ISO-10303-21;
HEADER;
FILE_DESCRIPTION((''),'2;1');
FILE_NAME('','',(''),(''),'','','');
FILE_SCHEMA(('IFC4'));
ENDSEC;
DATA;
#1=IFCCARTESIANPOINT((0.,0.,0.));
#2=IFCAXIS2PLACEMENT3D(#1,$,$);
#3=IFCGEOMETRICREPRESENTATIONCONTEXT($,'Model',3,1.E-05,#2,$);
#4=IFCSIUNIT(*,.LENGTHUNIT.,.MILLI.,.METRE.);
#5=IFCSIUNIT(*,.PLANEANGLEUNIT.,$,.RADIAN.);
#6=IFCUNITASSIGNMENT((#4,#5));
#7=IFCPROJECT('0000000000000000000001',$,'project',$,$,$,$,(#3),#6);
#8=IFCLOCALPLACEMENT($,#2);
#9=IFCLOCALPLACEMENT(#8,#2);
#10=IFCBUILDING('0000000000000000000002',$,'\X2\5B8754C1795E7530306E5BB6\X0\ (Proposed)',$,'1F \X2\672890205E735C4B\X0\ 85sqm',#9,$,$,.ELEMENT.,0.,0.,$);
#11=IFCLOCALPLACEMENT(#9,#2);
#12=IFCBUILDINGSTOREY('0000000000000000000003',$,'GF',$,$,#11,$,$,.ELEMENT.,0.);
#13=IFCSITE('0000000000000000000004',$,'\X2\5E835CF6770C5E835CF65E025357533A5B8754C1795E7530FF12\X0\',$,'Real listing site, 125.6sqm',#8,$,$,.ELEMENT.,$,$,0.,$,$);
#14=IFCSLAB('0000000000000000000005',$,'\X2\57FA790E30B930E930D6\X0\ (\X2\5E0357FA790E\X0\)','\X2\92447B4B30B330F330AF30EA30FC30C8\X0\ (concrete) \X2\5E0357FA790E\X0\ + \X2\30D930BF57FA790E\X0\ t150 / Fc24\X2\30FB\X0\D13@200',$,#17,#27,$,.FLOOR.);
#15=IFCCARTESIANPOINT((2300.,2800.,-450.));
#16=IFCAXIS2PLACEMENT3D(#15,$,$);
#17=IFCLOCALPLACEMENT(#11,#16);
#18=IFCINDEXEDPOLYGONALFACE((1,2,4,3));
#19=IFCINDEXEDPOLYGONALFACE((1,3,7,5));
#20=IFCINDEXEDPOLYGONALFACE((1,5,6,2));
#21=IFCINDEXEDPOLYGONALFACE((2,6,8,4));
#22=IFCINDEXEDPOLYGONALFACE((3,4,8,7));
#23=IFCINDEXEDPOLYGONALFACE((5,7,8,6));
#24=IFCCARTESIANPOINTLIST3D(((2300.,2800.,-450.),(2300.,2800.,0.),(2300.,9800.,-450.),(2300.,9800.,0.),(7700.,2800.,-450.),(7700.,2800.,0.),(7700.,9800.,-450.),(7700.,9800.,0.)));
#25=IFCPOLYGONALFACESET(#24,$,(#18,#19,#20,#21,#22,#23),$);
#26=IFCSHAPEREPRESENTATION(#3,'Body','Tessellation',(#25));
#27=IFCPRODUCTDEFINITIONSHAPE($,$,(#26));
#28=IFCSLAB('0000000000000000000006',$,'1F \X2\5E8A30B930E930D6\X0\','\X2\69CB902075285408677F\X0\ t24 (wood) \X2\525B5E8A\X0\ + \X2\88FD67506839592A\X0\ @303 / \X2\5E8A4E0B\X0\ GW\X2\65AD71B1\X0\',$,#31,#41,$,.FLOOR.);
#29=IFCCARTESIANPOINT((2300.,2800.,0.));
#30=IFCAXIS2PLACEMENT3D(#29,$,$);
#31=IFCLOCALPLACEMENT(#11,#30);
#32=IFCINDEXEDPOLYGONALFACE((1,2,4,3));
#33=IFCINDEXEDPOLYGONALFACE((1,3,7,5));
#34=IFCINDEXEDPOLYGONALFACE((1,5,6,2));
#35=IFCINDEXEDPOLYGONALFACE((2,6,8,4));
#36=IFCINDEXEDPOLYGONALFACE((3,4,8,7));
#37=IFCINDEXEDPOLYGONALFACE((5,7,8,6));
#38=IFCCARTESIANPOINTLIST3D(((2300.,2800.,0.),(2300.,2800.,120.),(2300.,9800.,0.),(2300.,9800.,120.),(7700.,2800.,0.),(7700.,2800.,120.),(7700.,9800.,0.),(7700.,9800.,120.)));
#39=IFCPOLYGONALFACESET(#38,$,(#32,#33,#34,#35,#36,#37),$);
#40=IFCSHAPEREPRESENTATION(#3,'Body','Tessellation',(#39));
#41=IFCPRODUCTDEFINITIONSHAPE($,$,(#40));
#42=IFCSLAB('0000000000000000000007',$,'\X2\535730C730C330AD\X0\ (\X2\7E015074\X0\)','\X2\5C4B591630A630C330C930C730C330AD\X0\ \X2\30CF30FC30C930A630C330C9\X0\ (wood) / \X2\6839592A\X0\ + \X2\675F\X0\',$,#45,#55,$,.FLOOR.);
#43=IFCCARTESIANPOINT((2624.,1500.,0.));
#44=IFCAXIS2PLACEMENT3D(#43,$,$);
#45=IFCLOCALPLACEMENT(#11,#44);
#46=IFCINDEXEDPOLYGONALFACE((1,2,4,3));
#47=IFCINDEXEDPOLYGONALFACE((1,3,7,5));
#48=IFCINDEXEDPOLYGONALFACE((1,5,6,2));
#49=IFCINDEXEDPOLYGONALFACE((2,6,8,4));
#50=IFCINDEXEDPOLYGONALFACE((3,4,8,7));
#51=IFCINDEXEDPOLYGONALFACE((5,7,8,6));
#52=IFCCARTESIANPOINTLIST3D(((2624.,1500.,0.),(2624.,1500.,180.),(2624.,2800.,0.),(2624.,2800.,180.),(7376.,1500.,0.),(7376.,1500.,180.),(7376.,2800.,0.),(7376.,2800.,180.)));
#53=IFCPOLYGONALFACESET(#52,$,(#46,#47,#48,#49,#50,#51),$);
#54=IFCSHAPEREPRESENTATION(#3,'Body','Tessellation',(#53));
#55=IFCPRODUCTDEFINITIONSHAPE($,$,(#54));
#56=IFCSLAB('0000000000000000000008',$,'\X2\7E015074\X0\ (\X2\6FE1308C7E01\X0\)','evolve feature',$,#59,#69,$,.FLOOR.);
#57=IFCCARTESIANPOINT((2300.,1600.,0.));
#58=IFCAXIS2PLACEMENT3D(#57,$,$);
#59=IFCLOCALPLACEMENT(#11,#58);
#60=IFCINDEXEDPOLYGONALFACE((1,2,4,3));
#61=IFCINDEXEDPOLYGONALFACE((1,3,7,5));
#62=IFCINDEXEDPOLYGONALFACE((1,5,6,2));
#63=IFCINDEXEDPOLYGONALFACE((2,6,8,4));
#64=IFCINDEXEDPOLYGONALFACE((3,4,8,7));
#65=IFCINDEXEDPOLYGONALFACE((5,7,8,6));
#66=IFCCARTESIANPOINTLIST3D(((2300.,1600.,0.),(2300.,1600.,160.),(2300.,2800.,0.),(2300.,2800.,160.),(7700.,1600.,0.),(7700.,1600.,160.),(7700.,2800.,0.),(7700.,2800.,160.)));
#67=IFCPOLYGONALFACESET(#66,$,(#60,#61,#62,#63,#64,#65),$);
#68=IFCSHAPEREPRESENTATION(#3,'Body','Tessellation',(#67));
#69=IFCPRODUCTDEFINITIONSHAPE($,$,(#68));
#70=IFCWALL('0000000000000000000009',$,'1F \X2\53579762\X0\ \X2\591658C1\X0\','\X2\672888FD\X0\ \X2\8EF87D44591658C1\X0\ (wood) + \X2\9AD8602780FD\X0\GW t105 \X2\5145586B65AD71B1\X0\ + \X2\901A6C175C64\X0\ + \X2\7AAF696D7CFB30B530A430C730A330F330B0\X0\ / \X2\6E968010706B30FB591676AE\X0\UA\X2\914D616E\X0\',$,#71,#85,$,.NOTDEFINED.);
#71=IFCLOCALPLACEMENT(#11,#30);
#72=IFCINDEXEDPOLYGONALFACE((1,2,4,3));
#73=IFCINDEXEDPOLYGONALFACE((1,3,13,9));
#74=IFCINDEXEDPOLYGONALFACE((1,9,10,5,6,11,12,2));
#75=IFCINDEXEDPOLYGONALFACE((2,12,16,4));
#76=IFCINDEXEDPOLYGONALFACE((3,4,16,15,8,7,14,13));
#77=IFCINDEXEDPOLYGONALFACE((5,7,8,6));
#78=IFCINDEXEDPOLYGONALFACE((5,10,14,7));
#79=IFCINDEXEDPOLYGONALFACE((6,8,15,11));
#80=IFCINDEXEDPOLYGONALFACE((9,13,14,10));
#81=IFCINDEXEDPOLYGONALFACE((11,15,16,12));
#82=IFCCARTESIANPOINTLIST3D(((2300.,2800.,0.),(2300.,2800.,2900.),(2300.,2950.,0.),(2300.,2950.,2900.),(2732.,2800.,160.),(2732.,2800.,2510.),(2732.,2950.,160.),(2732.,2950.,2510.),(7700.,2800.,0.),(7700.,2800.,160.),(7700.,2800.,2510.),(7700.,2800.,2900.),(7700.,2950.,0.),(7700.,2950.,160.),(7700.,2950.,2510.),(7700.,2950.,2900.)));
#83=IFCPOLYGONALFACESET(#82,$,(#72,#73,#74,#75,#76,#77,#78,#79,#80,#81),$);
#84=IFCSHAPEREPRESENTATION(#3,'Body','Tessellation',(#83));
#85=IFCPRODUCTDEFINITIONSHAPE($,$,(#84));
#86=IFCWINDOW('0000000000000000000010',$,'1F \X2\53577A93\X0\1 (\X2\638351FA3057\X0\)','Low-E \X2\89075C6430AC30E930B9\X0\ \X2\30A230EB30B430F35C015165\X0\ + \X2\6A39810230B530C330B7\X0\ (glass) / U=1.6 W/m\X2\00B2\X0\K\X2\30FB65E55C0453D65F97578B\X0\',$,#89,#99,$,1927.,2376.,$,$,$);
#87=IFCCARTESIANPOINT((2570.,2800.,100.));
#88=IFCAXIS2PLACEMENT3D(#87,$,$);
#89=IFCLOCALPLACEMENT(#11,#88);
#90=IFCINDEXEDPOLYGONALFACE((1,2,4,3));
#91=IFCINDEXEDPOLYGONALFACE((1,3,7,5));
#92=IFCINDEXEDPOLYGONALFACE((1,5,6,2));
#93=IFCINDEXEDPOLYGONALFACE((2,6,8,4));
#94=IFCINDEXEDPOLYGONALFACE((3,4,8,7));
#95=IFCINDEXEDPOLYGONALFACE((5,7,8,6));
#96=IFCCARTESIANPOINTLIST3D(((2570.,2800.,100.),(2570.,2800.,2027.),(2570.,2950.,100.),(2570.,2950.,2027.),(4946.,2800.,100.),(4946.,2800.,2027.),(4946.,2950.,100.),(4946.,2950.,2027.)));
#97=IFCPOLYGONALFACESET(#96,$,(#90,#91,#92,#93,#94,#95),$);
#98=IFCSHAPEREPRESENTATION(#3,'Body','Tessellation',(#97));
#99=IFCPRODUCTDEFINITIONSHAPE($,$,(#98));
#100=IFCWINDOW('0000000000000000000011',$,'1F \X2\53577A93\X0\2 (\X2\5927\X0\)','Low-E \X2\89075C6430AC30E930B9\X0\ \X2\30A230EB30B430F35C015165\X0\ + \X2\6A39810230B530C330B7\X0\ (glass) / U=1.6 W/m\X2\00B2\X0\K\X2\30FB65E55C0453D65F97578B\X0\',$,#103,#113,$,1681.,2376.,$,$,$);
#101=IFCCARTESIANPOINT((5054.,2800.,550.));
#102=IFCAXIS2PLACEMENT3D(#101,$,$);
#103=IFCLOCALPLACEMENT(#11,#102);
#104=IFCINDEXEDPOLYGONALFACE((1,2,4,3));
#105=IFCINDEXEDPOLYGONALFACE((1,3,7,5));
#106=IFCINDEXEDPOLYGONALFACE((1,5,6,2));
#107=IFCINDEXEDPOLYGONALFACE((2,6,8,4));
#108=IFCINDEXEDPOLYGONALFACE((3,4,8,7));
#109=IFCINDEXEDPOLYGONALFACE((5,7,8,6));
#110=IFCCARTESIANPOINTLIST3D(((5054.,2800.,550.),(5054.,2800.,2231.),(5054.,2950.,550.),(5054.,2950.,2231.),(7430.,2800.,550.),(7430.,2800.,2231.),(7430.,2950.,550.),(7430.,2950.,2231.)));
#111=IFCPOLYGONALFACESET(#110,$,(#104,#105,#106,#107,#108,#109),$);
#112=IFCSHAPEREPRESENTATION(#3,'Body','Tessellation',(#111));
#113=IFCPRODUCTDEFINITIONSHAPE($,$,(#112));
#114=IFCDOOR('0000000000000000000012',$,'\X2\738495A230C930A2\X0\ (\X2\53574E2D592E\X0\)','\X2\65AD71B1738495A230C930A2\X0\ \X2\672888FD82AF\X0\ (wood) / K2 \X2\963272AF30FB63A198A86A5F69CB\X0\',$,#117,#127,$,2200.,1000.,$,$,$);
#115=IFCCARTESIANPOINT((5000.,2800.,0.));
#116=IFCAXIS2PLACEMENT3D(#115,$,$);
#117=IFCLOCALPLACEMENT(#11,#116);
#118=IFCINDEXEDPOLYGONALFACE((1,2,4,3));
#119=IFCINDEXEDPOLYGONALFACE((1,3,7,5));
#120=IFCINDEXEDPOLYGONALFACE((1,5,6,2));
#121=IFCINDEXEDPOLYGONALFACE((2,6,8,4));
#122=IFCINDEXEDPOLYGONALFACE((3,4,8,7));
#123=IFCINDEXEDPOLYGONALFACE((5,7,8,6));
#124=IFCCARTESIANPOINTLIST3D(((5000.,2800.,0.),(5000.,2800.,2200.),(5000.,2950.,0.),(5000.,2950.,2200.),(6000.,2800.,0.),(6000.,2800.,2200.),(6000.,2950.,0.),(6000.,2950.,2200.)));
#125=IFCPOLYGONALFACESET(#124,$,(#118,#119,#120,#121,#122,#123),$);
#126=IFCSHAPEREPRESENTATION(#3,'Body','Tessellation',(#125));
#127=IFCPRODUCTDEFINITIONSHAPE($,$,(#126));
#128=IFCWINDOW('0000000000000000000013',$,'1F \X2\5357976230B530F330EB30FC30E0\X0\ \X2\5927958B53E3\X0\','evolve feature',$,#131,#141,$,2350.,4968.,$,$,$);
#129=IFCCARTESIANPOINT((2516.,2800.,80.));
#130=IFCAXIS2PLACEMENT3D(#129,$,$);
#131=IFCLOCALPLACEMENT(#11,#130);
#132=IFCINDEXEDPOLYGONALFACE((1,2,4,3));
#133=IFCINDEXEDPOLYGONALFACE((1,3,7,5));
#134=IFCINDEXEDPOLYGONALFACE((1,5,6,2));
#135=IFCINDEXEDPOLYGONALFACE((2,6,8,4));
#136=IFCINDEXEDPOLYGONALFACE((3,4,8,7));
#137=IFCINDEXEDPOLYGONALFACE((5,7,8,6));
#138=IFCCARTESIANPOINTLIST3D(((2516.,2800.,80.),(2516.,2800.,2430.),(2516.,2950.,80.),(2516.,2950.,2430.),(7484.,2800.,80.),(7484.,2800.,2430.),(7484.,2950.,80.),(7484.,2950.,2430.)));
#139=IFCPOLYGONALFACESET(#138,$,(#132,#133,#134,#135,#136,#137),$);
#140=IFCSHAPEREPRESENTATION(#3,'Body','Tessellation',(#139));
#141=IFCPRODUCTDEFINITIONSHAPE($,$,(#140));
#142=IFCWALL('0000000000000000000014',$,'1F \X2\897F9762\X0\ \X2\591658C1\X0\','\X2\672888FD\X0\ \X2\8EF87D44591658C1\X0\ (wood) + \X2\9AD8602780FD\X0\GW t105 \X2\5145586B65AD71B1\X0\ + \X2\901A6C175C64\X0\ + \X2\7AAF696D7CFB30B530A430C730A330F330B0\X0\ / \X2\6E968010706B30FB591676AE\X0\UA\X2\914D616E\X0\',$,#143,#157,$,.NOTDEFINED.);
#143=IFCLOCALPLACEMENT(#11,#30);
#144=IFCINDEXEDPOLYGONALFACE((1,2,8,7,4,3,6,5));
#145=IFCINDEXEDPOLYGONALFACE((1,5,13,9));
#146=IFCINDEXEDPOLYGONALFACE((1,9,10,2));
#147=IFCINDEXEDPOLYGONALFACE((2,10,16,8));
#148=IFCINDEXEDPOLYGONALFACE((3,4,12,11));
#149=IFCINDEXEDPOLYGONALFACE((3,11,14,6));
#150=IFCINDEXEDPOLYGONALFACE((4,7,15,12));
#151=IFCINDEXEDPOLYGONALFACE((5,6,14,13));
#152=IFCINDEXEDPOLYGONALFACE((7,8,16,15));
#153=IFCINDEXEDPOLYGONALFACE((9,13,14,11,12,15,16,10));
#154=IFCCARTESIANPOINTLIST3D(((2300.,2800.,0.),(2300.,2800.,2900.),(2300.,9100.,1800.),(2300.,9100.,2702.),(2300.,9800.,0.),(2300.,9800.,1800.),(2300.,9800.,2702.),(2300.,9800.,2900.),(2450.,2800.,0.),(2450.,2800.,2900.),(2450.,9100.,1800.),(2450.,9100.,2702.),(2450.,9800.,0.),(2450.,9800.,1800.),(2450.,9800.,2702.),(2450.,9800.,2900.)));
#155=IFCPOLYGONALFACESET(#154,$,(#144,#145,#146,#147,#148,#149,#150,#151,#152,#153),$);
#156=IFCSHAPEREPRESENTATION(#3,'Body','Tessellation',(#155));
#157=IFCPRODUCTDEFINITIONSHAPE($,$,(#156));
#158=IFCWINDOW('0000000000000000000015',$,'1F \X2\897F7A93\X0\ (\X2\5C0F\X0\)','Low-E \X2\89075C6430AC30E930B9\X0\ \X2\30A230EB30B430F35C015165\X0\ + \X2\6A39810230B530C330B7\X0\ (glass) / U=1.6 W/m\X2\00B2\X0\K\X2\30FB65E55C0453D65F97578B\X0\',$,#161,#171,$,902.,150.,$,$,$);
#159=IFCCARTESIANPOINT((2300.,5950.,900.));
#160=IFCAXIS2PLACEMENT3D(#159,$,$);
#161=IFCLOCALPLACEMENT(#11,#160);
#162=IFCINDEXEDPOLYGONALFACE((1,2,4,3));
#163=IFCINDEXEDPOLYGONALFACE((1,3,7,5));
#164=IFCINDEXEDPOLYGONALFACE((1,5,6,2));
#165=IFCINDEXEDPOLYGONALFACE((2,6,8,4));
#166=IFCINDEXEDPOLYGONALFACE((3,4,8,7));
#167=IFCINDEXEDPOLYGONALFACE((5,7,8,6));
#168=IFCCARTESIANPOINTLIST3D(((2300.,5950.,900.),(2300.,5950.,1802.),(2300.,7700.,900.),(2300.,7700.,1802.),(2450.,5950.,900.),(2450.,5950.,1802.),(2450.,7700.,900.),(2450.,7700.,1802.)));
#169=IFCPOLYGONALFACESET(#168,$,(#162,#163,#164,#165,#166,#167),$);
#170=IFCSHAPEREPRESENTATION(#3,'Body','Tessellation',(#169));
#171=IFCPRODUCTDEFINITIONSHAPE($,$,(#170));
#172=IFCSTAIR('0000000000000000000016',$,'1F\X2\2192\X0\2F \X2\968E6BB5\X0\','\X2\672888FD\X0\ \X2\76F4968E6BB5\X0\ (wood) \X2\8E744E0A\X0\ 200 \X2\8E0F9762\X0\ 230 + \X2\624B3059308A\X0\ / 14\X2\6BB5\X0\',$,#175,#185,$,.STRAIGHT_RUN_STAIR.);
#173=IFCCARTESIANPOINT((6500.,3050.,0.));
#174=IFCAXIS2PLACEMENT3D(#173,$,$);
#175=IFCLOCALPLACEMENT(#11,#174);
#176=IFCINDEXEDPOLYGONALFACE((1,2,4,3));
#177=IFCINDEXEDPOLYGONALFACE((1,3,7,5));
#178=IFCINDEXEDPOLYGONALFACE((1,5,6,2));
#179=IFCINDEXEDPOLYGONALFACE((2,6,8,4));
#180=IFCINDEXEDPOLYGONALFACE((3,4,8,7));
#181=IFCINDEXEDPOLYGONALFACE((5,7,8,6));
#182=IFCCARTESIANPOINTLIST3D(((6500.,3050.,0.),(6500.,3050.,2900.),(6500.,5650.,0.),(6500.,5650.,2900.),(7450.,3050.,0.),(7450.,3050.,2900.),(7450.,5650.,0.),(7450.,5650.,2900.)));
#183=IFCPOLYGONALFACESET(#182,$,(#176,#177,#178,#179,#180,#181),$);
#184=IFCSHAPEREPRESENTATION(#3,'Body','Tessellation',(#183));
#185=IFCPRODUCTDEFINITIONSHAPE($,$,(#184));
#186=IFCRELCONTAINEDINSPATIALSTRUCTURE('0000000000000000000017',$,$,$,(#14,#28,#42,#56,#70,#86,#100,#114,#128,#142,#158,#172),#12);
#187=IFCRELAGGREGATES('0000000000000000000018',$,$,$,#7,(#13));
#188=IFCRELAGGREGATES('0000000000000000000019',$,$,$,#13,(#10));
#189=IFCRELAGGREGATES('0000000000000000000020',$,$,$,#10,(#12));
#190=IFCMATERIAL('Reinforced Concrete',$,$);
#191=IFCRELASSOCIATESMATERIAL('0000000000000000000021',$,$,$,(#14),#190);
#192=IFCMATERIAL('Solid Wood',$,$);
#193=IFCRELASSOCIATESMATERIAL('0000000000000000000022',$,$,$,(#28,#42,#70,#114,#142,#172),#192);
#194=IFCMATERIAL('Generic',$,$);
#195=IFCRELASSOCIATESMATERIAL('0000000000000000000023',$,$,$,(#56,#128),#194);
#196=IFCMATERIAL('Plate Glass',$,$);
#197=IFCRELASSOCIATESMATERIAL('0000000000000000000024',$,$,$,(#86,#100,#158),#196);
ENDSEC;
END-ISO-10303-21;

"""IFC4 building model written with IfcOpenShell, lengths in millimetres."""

from ifc_helpers import new_model, si_unit, frame, frame_2d, origin, place, context, project, spatial, rectangle, extrude, material, element, fill, save


model = new_model("IFC4")

# Units and contexts
model_context = context("Model", 3, precision=1e-05, world=origin())
ifc_project = project(units=[si_unit("LENGTHUNIT", "METRE", prefix="MILLI"), si_unit("PLANEANGLEUNIT", "RADIAN")], contexts=[model_context])

# Site, building, storey
site_placement = place(None, origin())
site = spatial("IfcSite", under=ifc_project, at=site_placement, Name="広島県広島市南区宇品神田２", ObjectType="Real listing site, 125.6sqm", CompositionType="ELEMENT", RefElevation=0.0)
building_placement = place(site_placement, origin())
building = spatial("IfcBuilding", under=site, at=building_placement, Name="宇品神田の家 (Proposed)", ObjectType="1F 木造平屋 85sqm", CompositionType="ELEMENT", ElevationOfRefHeight=0.0, ElevationOfTerrain=0.0)
storey_placement = place(building_placement, origin())
storey = spatial("IfcBuildingStorey", under=building, at=storey_placement, Name="GF", CompositionType="ELEMENT", Elevation=0.0)

# Slabs
ifc_material_1 = material(Name="Reinforced Concrete")
slab_1_placement = place(storey_placement, frame((2300.0, 2800.0, -450.0)))
element("IfcSlab", 1, at=slab_1_placement, inside=storey, material=ifc_material_1, Name="基礎スラブ (布基礎)", Description="鉄筋コンクリート (concrete) 布基礎 + ベタ基礎 t150 / Fc24・D13@200", PredefinedType="FLOOR", context=model_context, shape_type="SweptSolid", body=[
    extrude(rectangle(XDim=5400.0, YDim=7000.0, at=frame_2d((2700.0, 3500.0))), frame((2300.0, 2800.0, -450.0)), (0.0, 0.0, 1.0), 450.0),
])
ifc_material_2 = material(Name="Solid Wood")
slab_2_placement = place(storey_placement, frame((2300.0, 2800.0, 0.0)))
element("IfcSlab", 2, at=slab_2_placement, inside=storey, material=ifc_material_2, Name="1F 床スラブ", Description="構造用合板 t24 (wood) 剛床 + 製材根太 @303 / 床下 GW断熱", PredefinedType="FLOOR", context=model_context, shape_type="SweptSolid", body=[
    extrude(rectangle(XDim=5400.0, YDim=7000.0, at=frame_2d((2700.0, 3500.0))), frame((2300.0, 2800.0, 0.0)), (0.0, 0.0, 1.0), 120.0),
])
slab_3_placement = place(storey_placement, frame((2624.0, 1500.0, 0.0)))
element("IfcSlab", 3, at=slab_3_placement, inside=storey, material=ifc_material_2, Name="南デッキ (縁側)", Description="屋外ウッドデッキ ハードウッド (wood) / 根太 + 束", PredefinedType="FLOOR", context=model_context, shape_type="SweptSolid", body=[
    extrude(rectangle(XDim=4752.0, YDim=1300.0, at=frame_2d((2376.0, 650.0))), frame((2624.0, 1500.0, 0.0)), (0.0, 0.0, 1.0), 180.0),
])
ifc_material_3 = material(Name="Generic")
slab_4_placement = place(storey_placement, frame((2300.0, 1600.0, 0.0)))
element("IfcSlab", 4, at=slab_4_placement, inside=storey, material=ifc_material_3, Name="縁側 (濡れ縁)", Description="evolve feature", PredefinedType="FLOOR", context=model_context, shape_type="SweptSolid", body=[
    extrude(rectangle(XDim=5400.0, YDim=1200.0, at=frame_2d((2700.0, 600.0))), frame((2300.0, 1600.0, 0.0)), (0.0, 0.0, 1.0), 160.0),
])

# Wall, openings, windows, door
wall_1_placement = place(storey_placement, frame((2300.0, 2800.0, 0.0)))
wall_1 = element("IfcWall", 5, at=wall_1_placement, inside=storey, material=ifc_material_2, Name="1F 南面 外壁", Description="木製 軸組外壁 (wood) + 高性能GW t105 充填断熱 + 通気層 + 窯業系サイディング / 準耐火・外皮UA配慮", PredefinedType="NOTDEFINED", context=model_context, shape_type="SweptSolid", body=[
    extrude(rectangle(XDim=5400.0, YDim=150.0, at=frame_2d((2700.0, 75.0))), frame((2300.0, 2800.0, 0.0)), (0.0, 0.0, 1.0), 2900.0),
])
opening_1_placement = place(storey_placement, frame((2570.0, 2800.0, 100.0)))
opening_1 = element("IfcOpeningElement", 6, at=opening_1_placement, cuts=wall_1, PredefinedType="NOTDEFINED", context=model_context, shape_type="SweptSolid", body=[
    extrude(rectangle(XDim=2376.0, YDim=150.0, at=frame_2d((1188.0, 75.0))), frame((2570.0, 2800.0, 100.0)), (0.0, 0.0, 1.0), 1927.0),
])
opening_2_placement = place(storey_placement, frame((5054.0, 2800.0, 550.0)))
opening_2 = element("IfcOpeningElement", 7, at=opening_2_placement, cuts=wall_1, PredefinedType="NOTDEFINED", context=model_context, shape_type="SweptSolid", body=[
    extrude(rectangle(XDim=2376.0, YDim=150.0, at=frame_2d((1188.0, 75.0))), frame((5054.0, 2800.0, 550.0)), (0.0, 0.0, 1.0), 1681.0),
])
opening_3_placement = place(storey_placement, frame((5000.0, 2800.0, 0.0)))
opening_3 = element("IfcOpeningElement", 8, at=opening_3_placement, cuts=wall_1, PredefinedType="NOTDEFINED", context=model_context, shape_type="SweptSolid", body=[
    extrude(rectangle(XDim=1000.0, YDim=150.0, at=frame_2d((500.0, 75.0))), frame((5000.0, 2800.0, 0.0)), (0.0, 0.0, 1.0), 2200.0),
])
opening_4_placement = place(storey_placement, frame((2516.0, 2800.0, 80.0)))
opening_4 = element("IfcOpeningElement", 9, at=opening_4_placement, cuts=wall_1, PredefinedType="NOTDEFINED", context=model_context, shape_type="SweptSolid", body=[
    extrude(rectangle(XDim=4968.0, YDim=150.0, at=frame_2d((2484.0, 75.0))), frame((2516.0, 2800.0, 80.0)), (0.0, 0.0, 1.0), 2350.0),
])
ifc_material_4 = material(Name="Plate Glass")
window_1_placement = place(storey_placement, frame((2570.0, 2800.0, 100.0)))
window_1 = element("IfcWindow", 10, at=window_1_placement, inside=storey, material=ifc_material_4, Name="1F 南窓1 (掃出し)", Description="Low-E 複層ガラス アルゴン封入 + 樹脂サッシ (glass) / U=1.6 W/m²K・日射取得型", OverallHeight=1927.0, OverallWidth=2376.0, context=model_context, shape_type="SweptSolid", body=[
    extrude(rectangle(XDim=2376.0, YDim=150.0, at=frame_2d((1188.0, 75.0))), frame((2570.0, 2800.0, 100.0)), (0.0, 0.0, 1.0), 1927.0),
])
fill(opening_1, window_1)
window_2_placement = place(storey_placement, frame((5054.0, 2800.0, 550.0)))
window_2 = element("IfcWindow", 11, at=window_2_placement, inside=storey, material=ifc_material_4, Name="1F 南窓2 (大)", Description="Low-E 複層ガラス アルゴン封入 + 樹脂サッシ (glass) / U=1.6 W/m²K・日射取得型", OverallHeight=1681.0, OverallWidth=2376.0, context=model_context, shape_type="SweptSolid", body=[
    extrude(rectangle(XDim=2376.0, YDim=150.0, at=frame_2d((1188.0, 75.0))), frame((5054.0, 2800.0, 550.0)), (0.0, 0.0, 1.0), 1681.0),
])
fill(opening_2, window_2)
door_placement = place(storey_placement, frame((5000.0, 2800.0, 0.0)))
door = element("IfcDoor", 12, at=door_placement, inside=storey, material=ifc_material_2, Name="玄関ドア (南中央)", Description="断熱玄関ドア 木製芯 (wood) / K2 防犯・採風機構", OverallHeight=2200.0, OverallWidth=1000.0, context=model_context, shape_type="SweptSolid", body=[
    extrude(rectangle(XDim=1000.0, YDim=150.0, at=frame_2d((500.0, 75.0))), frame((5000.0, 2800.0, 0.0)), (0.0, 0.0, 1.0), 2200.0),
])
fill(opening_3, door)
window_3_placement = place(storey_placement, frame((2516.0, 2800.0, 80.0)))
window_3 = element("IfcWindow", 13, at=window_3_placement, inside=storey, material=ifc_material_3, Name="1F 南面サンルーム 大開口", Description="evolve feature", OverallHeight=2350.0, OverallWidth=4968.0, context=model_context, shape_type="SweptSolid", body=[
    extrude(rectangle(XDim=4968.0, YDim=150.0, at=frame_2d((2484.0, 75.0))), frame((2516.0, 2800.0, 80.0)), (0.0, 0.0, 1.0), 2350.0),
])
fill(opening_4, window_3)

# Wall, opening, window
wall_2_placement = place(storey_placement, frame((2300.0, 2800.0, 0.0)))
wall_2 = element("IfcWall", 14, at=wall_2_placement, inside=storey, material=ifc_material_2, Name="1F 西面 外壁", Description="木製 軸組外壁 (wood) + 高性能GW t105 充填断熱 + 通気層 + 窯業系サイディング / 準耐火・外皮UA配慮", PredefinedType="NOTDEFINED", context=model_context, shape_type="SweptSolid", body=[
    extrude(rectangle(XDim=150.0, YDim=7000.0, at=frame_2d((75.0, 3500.0))), frame((2300.0, 2800.0, 0.0)), (0.0, 0.0, 1.0), 2900.0),
])
opening_5_placement = place(storey_placement, frame((2300.0, 5950.0, 900.0)))
opening_5 = element("IfcOpeningElement", 15, at=opening_5_placement, cuts=wall_2, PredefinedType="NOTDEFINED", context=model_context, shape_type="SweptSolid", body=[
    extrude(rectangle(XDim=150.0, YDim=1750.0, at=frame_2d((75.0, 875.0))), frame((2300.0, 5950.0, 900.0)), (0.0, 0.0, 1.0), 902.0),
])
window_4_placement = place(storey_placement, frame((2300.0, 5950.0, 900.0)))
window_4 = element("IfcWindow", 16, at=window_4_placement, inside=storey, material=ifc_material_4, Name="1F 西窓 (小)", Description="Low-E 複層ガラス アルゴン封入 + 樹脂サッシ (glass) / U=1.6 W/m²K・日射取得型", OverallHeight=902.0, OverallWidth=150.0, context=model_context, shape_type="SweptSolid", body=[
    extrude(rectangle(XDim=150.0, YDim=1750.0, at=frame_2d((75.0, 875.0))), frame((2300.0, 5950.0, 900.0)), (0.0, 0.0, 1.0), 902.0),
])
fill(opening_5, window_4)

# Stair
stair_placement = place(storey_placement, frame((6500.0, 3050.0, 0.0)))
element("IfcStair", 17, at=stair_placement, inside=storey, material=ifc_material_2, Name="1F→2F 階段", Description="木製 直階段 (wood) 蹴上 200 踏面 230 + 手すり / 14段", PredefinedType="STRAIGHT_RUN_STAIR", context=model_context, shape_type="SweptSolid", body=[
    extrude(rectangle(XDim=950.0, YDim=2600.0, at=frame_2d((475.0, 1300.0))), frame((6500.0, 3050.0, 0.0)), (0.0, 0.0, 1.0), 2900.0),
])

save(model, "model.ifc")
